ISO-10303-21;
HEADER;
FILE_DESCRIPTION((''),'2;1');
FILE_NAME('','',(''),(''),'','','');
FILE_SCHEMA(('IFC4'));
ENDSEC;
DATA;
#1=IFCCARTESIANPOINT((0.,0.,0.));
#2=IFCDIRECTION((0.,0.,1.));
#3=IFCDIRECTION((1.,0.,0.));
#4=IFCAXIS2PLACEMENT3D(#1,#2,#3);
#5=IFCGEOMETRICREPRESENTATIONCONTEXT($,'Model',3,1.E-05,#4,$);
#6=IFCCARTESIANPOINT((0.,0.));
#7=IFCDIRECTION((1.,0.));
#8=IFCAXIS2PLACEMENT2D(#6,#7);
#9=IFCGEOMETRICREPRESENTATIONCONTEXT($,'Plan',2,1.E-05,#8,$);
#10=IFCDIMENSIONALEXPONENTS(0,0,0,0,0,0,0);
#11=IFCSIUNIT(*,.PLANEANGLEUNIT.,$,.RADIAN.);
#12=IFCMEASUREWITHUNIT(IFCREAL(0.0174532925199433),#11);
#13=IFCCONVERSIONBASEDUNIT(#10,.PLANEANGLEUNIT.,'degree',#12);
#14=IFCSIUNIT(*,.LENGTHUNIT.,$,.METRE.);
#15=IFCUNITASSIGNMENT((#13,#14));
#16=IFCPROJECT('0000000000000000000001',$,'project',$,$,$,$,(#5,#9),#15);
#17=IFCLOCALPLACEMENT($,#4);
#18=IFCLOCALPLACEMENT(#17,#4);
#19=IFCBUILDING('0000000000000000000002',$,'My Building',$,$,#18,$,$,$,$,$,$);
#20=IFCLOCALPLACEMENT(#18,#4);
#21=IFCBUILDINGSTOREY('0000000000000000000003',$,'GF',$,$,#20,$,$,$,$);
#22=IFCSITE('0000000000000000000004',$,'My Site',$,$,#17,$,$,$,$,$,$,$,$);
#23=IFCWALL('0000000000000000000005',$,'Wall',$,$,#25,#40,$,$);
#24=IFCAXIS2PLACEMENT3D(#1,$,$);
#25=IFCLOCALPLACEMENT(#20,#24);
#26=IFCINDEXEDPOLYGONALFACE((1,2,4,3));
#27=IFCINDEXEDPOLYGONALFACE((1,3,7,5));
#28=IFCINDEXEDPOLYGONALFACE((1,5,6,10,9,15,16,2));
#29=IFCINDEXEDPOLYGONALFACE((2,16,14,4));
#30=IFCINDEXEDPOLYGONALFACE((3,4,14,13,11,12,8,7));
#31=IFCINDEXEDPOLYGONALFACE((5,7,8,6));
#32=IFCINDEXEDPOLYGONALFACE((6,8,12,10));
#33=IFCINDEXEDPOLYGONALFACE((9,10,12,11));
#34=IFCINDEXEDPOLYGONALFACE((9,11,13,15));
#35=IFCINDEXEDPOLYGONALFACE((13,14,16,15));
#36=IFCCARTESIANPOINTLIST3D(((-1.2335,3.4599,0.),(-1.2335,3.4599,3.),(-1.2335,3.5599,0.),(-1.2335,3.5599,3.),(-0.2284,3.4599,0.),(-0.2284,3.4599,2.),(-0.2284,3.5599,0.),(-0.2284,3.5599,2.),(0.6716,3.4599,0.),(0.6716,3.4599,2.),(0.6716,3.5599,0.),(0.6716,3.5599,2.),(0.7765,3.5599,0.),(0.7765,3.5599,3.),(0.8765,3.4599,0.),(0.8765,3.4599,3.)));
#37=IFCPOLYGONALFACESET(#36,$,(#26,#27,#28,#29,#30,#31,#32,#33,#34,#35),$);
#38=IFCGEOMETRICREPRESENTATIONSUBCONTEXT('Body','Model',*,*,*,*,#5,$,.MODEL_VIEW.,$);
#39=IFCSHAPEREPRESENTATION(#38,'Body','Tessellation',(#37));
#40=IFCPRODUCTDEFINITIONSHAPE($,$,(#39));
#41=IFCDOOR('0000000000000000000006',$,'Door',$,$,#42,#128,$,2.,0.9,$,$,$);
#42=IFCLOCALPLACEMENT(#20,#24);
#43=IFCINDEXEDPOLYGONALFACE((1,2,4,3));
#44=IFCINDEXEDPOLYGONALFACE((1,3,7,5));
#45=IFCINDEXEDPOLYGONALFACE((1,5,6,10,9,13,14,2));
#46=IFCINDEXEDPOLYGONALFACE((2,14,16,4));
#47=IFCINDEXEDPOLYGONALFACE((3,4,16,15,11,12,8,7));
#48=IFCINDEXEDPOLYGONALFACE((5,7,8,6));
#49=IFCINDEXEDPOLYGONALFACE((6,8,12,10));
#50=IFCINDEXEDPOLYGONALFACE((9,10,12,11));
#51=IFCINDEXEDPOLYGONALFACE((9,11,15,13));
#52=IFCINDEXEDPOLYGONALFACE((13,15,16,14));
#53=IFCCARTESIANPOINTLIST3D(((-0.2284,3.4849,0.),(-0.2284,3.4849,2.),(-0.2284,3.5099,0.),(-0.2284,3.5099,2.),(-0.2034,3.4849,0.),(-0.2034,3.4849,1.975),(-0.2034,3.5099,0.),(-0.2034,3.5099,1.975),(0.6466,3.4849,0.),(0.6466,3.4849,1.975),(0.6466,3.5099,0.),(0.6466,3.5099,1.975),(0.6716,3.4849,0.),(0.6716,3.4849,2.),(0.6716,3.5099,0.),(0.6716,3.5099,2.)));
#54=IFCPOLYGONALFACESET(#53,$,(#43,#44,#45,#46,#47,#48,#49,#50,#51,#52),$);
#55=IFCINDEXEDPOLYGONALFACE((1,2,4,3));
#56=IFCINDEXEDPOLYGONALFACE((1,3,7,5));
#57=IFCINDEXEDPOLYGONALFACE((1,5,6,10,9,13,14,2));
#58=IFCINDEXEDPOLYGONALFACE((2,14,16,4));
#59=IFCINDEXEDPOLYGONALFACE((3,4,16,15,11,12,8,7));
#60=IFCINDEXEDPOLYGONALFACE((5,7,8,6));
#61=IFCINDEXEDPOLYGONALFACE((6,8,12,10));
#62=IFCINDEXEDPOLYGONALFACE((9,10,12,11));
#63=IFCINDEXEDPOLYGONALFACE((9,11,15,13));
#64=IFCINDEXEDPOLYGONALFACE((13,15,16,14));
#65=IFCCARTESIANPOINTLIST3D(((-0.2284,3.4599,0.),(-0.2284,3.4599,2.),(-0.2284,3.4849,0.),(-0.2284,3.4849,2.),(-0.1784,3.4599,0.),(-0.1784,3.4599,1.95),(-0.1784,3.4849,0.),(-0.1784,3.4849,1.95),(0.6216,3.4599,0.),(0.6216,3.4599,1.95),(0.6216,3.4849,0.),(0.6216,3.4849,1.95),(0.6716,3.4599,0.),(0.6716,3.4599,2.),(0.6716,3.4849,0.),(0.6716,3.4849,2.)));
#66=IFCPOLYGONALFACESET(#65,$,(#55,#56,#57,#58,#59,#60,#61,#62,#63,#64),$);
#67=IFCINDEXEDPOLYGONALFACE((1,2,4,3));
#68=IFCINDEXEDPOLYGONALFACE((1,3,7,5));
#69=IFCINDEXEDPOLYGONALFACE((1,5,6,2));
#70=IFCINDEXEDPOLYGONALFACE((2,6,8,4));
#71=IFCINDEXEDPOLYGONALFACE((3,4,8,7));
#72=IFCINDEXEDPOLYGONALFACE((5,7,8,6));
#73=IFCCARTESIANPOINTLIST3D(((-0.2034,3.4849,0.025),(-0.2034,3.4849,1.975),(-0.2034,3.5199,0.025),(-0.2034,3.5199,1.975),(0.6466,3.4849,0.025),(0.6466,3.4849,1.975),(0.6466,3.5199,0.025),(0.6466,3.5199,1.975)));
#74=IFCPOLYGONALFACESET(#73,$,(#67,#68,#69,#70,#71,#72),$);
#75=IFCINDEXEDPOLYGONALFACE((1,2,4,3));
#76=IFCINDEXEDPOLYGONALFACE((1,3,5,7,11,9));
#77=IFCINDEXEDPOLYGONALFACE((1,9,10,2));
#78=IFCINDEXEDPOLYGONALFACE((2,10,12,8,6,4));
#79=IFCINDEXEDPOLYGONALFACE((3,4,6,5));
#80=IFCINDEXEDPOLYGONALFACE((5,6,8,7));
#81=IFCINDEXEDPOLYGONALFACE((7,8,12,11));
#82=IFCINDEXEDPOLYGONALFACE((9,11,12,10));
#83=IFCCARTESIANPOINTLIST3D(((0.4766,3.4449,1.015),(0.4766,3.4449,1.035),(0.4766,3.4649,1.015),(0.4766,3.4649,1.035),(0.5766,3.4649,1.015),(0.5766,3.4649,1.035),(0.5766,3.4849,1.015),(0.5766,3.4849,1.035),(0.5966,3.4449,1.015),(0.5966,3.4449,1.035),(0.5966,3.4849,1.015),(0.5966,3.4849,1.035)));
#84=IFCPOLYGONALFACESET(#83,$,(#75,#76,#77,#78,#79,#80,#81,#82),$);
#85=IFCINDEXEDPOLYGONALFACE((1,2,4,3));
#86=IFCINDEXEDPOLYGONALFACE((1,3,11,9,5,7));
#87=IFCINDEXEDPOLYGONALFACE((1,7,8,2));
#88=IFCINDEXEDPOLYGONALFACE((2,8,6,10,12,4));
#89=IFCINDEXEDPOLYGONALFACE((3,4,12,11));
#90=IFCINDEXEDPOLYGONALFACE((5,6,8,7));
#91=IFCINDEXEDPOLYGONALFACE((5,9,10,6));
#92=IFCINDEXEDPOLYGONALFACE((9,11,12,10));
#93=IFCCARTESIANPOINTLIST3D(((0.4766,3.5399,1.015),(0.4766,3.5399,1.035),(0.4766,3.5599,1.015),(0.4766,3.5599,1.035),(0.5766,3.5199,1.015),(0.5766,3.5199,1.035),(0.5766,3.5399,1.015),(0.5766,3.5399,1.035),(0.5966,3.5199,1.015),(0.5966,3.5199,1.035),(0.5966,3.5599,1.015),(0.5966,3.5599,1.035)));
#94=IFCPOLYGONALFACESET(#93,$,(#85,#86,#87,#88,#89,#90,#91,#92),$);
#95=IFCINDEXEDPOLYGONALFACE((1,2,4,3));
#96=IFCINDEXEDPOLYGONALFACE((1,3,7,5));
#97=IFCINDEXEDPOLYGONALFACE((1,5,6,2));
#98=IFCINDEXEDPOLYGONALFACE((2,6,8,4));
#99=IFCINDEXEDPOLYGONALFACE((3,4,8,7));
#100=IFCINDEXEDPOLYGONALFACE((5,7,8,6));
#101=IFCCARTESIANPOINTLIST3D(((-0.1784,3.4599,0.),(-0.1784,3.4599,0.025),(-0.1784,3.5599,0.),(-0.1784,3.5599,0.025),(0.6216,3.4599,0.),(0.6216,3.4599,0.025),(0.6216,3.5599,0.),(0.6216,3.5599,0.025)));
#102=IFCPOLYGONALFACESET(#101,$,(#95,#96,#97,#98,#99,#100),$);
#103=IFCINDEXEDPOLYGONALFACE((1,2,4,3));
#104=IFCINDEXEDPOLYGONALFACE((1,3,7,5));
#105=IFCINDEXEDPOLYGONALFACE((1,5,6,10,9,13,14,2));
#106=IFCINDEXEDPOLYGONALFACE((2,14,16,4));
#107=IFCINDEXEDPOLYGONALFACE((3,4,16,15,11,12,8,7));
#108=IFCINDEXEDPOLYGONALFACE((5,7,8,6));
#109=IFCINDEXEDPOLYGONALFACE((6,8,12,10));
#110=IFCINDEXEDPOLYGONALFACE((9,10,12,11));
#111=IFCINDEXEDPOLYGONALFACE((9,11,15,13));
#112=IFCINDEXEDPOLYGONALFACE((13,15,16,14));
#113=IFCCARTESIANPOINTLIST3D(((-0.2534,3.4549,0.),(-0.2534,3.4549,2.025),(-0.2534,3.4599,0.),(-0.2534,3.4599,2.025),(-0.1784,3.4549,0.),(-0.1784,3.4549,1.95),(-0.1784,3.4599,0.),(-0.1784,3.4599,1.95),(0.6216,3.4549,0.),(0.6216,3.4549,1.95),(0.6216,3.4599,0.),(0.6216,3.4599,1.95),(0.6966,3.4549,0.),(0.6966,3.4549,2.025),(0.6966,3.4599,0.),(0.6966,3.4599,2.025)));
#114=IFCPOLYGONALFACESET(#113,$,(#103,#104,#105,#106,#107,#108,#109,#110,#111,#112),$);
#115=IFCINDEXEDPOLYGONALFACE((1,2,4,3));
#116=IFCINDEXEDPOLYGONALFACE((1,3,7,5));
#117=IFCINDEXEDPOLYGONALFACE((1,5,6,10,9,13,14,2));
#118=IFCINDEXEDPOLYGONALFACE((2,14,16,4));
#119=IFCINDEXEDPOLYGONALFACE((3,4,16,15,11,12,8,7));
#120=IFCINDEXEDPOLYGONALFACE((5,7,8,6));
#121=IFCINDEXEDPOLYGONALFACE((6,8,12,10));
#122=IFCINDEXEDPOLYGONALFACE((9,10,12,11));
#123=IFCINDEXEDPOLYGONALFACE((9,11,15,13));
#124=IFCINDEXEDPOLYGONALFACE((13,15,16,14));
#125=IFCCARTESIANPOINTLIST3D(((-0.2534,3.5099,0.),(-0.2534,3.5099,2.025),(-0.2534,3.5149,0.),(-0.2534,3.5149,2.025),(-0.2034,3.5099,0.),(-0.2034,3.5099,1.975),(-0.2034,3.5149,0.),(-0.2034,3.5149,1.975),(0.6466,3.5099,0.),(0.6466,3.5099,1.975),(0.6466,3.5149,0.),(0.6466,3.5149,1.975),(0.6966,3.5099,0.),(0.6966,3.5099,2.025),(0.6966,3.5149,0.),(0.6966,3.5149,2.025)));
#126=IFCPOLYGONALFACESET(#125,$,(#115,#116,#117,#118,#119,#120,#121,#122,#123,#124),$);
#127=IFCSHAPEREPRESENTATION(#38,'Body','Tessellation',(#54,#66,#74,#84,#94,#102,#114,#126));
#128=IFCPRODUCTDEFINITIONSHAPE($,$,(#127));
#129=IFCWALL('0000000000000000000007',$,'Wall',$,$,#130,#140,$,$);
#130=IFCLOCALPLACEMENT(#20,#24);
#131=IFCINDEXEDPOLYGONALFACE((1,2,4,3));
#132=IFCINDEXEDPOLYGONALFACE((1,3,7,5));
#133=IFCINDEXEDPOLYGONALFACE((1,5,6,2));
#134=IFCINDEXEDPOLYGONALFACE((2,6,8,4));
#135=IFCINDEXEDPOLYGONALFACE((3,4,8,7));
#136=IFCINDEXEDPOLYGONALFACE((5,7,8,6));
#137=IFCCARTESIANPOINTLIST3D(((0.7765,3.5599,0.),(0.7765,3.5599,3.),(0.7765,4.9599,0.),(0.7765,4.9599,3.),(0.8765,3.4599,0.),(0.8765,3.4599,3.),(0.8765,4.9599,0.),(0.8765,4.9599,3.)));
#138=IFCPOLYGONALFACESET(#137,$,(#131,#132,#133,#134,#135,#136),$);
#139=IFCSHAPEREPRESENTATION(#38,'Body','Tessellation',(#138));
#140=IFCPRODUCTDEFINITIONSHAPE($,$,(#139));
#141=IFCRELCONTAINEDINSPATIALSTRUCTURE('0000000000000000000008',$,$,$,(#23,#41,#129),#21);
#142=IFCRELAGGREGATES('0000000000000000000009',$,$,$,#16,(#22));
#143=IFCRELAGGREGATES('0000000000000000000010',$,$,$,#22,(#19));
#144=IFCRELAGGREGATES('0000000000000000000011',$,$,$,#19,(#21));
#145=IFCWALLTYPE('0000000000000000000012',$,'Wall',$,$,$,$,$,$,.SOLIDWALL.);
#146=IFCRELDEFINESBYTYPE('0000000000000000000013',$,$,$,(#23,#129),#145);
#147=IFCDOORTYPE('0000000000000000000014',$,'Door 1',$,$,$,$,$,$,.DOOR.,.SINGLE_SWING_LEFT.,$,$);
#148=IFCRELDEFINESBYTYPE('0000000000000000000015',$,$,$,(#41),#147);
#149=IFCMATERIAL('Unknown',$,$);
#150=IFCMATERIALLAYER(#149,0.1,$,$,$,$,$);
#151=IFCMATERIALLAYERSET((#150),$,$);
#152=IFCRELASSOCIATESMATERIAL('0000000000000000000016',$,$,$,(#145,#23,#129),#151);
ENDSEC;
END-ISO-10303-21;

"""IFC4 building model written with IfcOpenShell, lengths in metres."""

from ifc_helpers import new_model, entity, si_unit, converted_unit, frame, origin_with_axes, origin_2d_with_axis, place, context, subcontext, project, spatial, line, indexed_curve, outline, extrude, shape, source, transform, mapped, material, layer, layer_set, layer_usage, type_object, type_shapes, element, fill, save


model = new_model("IFC4")

# Units and contexts
model_context = context("Model", 3, precision=1e-05, world=origin_with_axes())
plan_context = context("Plan", 2, precision=1e-05, world=origin_2d_with_axis())
body_context_1 = subcontext(model_context, "Body", "Model", "MODEL_VIEW")
body_context_2 = subcontext(plan_context, "Body", "Plan", "PLAN_VIEW")
ifc_project = project(units=[converted_unit("PLANEANGLEUNIT", "degree", entity("IfcReal", 0.0174532925199433), si_unit("PLANEANGLEUNIT", "RADIAN"), dimensions=[0, 0, 0, 0, 0, 0, 0]), si_unit("LENGTHUNIT", "METRE")], contexts=[model_context, plan_context])

# Site, building, storey
site_placement = place(None, origin_with_axes())
site = spatial("IfcSite", under=ifc_project, at=site_placement, Name="My Site")
building_placement = place(site_placement, origin_with_axes())
building = spatial("IfcBuilding", under=site, at=building_placement, Name="My Building")
storey_placement = place(building_placement, origin_with_axes())
storey = spatial("IfcBuildingStorey", under=building, at=storey_placement, Name="GF")

# Shared definitions
ifc_material = material(Name="Unknown")

# Shared definitions
ifc_layer = layer(ifc_material, 0.1)
ifc_layer_set = layer_set([ifc_layer])
wall_type = type_object("IfcWallType", Name="Wall", PredefinedType="SOLIDWALL", material=ifc_layer_set)

# Wall, opening, door
ifc_layer_usage_1 = layer_usage(ifc_layer_set, "AXIS2", "POSITIVE", 0.0)
wall_1_placement = place(storey_placement, frame((-1.2335, 3.4599, 0.0), z_axis=(0.0, 0.0, 1.0), x_axis=(1.0, 0.0, 0.0)))
wall_1 = element("IfcWall", 1, at=wall_1_placement, inside=storey, type_object=wall_type, material=ifc_layer_usage_1, Name="Wall", context=body_context_1, shape_type="SweptSolid", body=[
    extrude(outline(indexed_curve([(0.0, 0.0), (0.0, 0.1), (2.01, 0.1), (2.11, 0.0)], segments=[line(1, 2, 3, 4, 1)])), origin_with_axes(), (0.0, 0.0, 1.0), 3.0),
])
shared_shape_1 = source(origin_with_axes(), body_context_1, "Body", "SweptSolid", [
    extrude(outline(indexed_curve([(0.0, 0.0), (0.9, 0.0), (0.9, 2.0), (0.0, 2.0)], segments=[line(1, 2, 3, 4, 1)])), frame((0.0, -0.6, 0.0), z_axis=(0.0, -1.0, 0.0), x_axis=(1.0, 0.0, 0.0)), (0.0, 0.0, -1.0), 1.2),
])
opening_1_placement = place(wall_1_placement, frame((1.0051, 0.0, 0.0), z_axis=(0.0, 0.0, 1.0), x_axis=(1.0, 0.0, 0.0)))
opening_1 = element("IfcOpeningElement", 2, at=opening_1_placement, cuts=wall_1, PredefinedType="OPENING", context=body_context_1, shape_type="MappedRepresentation", body=[
    mapped(shared_shape_1, transform((0.0, 0.0, 0.0), x_axis=(1.0, 0.0, 0.0), y_axis=(0.0, 1.0, 0.0), z_axis=(0.0, 0.0, 1.0), scale=1.0)),
])
door_type = type_object("IfcDoorType", Name="Door 1", OperationType="SINGLE_SWING_LEFT", PredefinedType="DOOR")
shared_shape_2 = source(origin_with_axes(), body_context_1, "Body", "SweptSolid", [
    extrude(outline(indexed_curve([(0.0, 0.0), (0.0, 2.0), (0.9, 2.0), (0.9, 0.0), (0.875, 0.0), (0.875, 1.975), (0.025, 1.975), (0.025, 0.0)], segments=[line(1, 2, 3, 4, 5, 6, 7, 8, 1)])), frame((0.0, 0.025, 0.0), z_axis=(0.0, -1.0, 0.0), x_axis=(1.0, 0.0, 0.0)), (0.0, 0.0, -1.0), 0.025),
    extrude(outline(indexed_curve([(0.0, 0.0), (0.0, 2.0), (0.9, 2.0), (0.9, 0.0), (0.85, 0.0), (0.85, 1.95), (0.05, 1.95), (0.05, 0.0)], segments=[line(1, 2, 3, 4, 5, 6, 7, 8, 1)])), frame((0.0, 0.0, 0.0), z_axis=(0.0, -1.0, 0.0), x_axis=(1.0, 0.0, 0.0)), (0.0, 0.0, -1.0), 0.025),
    extrude(outline(indexed_curve([(0.0, 0.0), (0.85, 0.0), (0.85, 0.035), (0.0, 0.035)], segments=[line(1, 2, 3, 4, 1)])), frame((0.025, 0.025, 0.025), z_axis=(0.0, 0.0, 1.0), x_axis=(1.0, 0.0, 0.0)), (0.0, 0.0, 1.0), 1.95),
    extrude(outline(indexed_curve([(0.0, 0.0), (0.0, -0.04), (-0.12, -0.04), (-0.12, -0.02), (-0.02, -0.02), (-0.02, 0.0)], segments=[line(1, 2, 3, 4, 5, 6, 1)])), frame((0.825, 0.025, 1.015), z_axis=(0.0, 0.0, 1.0), x_axis=(1.0, 0.0, 0.0)), (0.0, 0.0, 1.0), 0.02),
    extrude(outline(indexed_curve([(0.0, 0.0), (0.0, 0.04), (-0.12, 0.04), (-0.12, 0.02), (-0.02, 0.02), (-0.02, 0.0)], segments=[line(1, 2, 3, 4, 5, 6, 1)])), frame((0.825, 0.06, 1.015), z_axis=(0.0, 0.0, 1.0), x_axis=(1.0, 0.0, 0.0)), (0.0, 0.0, 1.0), 0.02),
    extrude(outline(indexed_curve([(0.0, 0.0), (0.8, 0.0), (0.8, 0.1), (0.0, 0.1)], segments=[line(1, 2, 3, 4, 1)])), frame((0.05, 0.0, 0.0), z_axis=(0.0, 0.0, 1.0), x_axis=(1.0, 0.0, 0.0)), (0.0, 0.0, 1.0), 0.025),
    extrude(outline(indexed_curve([(0.0, 0.0), (0.0, 2.025), (0.95, 2.025), (0.95, 0.0), (0.875, 0.0), (0.875, 1.95), (0.075, 1.95), (0.075, 0.0)], segments=[line(1, 2, 3, 4, 5, 6, 7, 8, 1)])), frame((-0.025, -0.005, 0.0), z_axis=(0.0, -1.0, 0.0), x_axis=(1.0, 0.0, 0.0)), (0.0, 0.0, -1.0), 0.005),
    extrude(outline(indexed_curve([(0.0, 0.0), (0.0, 2.025), (0.95, 2.025), (0.95, 0.0), (0.9, 0.0), (0.9, 1.975), (0.05, 1.975), (0.05, 0.0)], segments=[line(1, 2, 3, 4, 5, 6, 7, 8, 1)])), frame((-0.025, 0.05, 0.0), z_axis=(0.0, -1.0, 0.0), x_axis=(1.0, 0.0, 0.0)), (0.0, 0.0, -1.0), 0.005),
])
shared_shape_3 = source(origin_with_axes(), body_context_2, "Body", "Curve2D", [
    entity("IfcIndexedPolyCurve", entity("IfcCartesianPointList2D", [[0.0, 0.0], [0.0, 0.05], [0.025, 0.05], [0.025, 0.025], [0.05, 0.025], [0.05, 0.0]]), [entity("IfcLineIndex", [1, 2, 3, 4, 5, 6, 1])]),
    entity("IfcIndexedPolyCurve", entity("IfcCartesianPointList2D", [[0.9, 0.0], [0.9, 0.05], [0.875, 0.05], [0.875, 0.025], [0.85, 0.025], [0.85, 0.0]]), [entity("IfcLineIndex", [1, 2, 3, 4, 5, 6, 1])]),
    entity("IfcTrimmedCurve", entity("IfcEllipse", entity("IfcAxis2Placement2D", entity("IfcCartesianPoint", [0.06, 0.05]), entity("IfcDirection", [1.0, 0.0])), 0.815, 0.85), [entity("IfcCartesianPoint", [0.875, 0.05])], [entity("IfcCartesianPoint", [0.06, 0.9])], True, "CARTESIAN"),
    entity("IfcIndexedPolyCurve", entity("IfcCartesianPointList2D", [[0.025, 0.05], [0.06, 0.05], [0.06, 0.9], [0.025, 0.9]]), [entity("IfcLineIndex", [1, 2, 3, 4, 1])]),
])
type_shapes(door_type, [shared_shape_2, shared_shape_3])
door_placement = place(opening_1_placement, origin_with_axes())
door = element("IfcDoor", 3, at=door_placement, inside=storey, type_object=door_type, Name="Door", OverallHeight=2.0, OverallWidth=0.9, shapes=[
    shape(body_context_1, "Body", "MappedRepresentation", [mapped(shared_shape_2, transform((0.0, 0.0, 0.0), x_axis=(1.0, 0.0, 0.0), y_axis=(0.0, 1.0, 0.0), z_axis=(0.0, 0.0, 1.0), scale=1.0))]),
    shape(body_context_2, "Body", "MappedRepresentation", [mapped(shared_shape_3, transform((0.0, 0.0, 0.0), x_axis=(1.0, 0.0, 0.0), y_axis=(0.0, 1.0, 0.0), z_axis=(0.0, 0.0, 1.0), scale=1.0))]),
])
fill(opening_1, door)

# Wall
ifc_layer_usage_2 = layer_usage(ifc_layer_set, "AXIS2", "POSITIVE", 0.0)
wall_2_placement = place(storey_placement, frame((0.8765, 3.4599, 0.0), z_axis=(0.0, 0.0, 1.0), x_axis=(0.0, 1.0, 0.0)))
element("IfcWall", 4, at=wall_2_placement, inside=storey, type_object=wall_type, material=ifc_layer_usage_2, Name="Wall", context=body_context_1, shape_type="SweptSolid", body=[
    extrude(outline(indexed_curve([(0.0, 0.0), (0.1, 0.1), (1.5, 0.1), (1.5, 0.0)], segments=[line(1, 2, 3, 4, 1)])), origin_with_axes(), (0.0, 0.0, 1.0), 3.0),
])

save(model, "model.ifc")
